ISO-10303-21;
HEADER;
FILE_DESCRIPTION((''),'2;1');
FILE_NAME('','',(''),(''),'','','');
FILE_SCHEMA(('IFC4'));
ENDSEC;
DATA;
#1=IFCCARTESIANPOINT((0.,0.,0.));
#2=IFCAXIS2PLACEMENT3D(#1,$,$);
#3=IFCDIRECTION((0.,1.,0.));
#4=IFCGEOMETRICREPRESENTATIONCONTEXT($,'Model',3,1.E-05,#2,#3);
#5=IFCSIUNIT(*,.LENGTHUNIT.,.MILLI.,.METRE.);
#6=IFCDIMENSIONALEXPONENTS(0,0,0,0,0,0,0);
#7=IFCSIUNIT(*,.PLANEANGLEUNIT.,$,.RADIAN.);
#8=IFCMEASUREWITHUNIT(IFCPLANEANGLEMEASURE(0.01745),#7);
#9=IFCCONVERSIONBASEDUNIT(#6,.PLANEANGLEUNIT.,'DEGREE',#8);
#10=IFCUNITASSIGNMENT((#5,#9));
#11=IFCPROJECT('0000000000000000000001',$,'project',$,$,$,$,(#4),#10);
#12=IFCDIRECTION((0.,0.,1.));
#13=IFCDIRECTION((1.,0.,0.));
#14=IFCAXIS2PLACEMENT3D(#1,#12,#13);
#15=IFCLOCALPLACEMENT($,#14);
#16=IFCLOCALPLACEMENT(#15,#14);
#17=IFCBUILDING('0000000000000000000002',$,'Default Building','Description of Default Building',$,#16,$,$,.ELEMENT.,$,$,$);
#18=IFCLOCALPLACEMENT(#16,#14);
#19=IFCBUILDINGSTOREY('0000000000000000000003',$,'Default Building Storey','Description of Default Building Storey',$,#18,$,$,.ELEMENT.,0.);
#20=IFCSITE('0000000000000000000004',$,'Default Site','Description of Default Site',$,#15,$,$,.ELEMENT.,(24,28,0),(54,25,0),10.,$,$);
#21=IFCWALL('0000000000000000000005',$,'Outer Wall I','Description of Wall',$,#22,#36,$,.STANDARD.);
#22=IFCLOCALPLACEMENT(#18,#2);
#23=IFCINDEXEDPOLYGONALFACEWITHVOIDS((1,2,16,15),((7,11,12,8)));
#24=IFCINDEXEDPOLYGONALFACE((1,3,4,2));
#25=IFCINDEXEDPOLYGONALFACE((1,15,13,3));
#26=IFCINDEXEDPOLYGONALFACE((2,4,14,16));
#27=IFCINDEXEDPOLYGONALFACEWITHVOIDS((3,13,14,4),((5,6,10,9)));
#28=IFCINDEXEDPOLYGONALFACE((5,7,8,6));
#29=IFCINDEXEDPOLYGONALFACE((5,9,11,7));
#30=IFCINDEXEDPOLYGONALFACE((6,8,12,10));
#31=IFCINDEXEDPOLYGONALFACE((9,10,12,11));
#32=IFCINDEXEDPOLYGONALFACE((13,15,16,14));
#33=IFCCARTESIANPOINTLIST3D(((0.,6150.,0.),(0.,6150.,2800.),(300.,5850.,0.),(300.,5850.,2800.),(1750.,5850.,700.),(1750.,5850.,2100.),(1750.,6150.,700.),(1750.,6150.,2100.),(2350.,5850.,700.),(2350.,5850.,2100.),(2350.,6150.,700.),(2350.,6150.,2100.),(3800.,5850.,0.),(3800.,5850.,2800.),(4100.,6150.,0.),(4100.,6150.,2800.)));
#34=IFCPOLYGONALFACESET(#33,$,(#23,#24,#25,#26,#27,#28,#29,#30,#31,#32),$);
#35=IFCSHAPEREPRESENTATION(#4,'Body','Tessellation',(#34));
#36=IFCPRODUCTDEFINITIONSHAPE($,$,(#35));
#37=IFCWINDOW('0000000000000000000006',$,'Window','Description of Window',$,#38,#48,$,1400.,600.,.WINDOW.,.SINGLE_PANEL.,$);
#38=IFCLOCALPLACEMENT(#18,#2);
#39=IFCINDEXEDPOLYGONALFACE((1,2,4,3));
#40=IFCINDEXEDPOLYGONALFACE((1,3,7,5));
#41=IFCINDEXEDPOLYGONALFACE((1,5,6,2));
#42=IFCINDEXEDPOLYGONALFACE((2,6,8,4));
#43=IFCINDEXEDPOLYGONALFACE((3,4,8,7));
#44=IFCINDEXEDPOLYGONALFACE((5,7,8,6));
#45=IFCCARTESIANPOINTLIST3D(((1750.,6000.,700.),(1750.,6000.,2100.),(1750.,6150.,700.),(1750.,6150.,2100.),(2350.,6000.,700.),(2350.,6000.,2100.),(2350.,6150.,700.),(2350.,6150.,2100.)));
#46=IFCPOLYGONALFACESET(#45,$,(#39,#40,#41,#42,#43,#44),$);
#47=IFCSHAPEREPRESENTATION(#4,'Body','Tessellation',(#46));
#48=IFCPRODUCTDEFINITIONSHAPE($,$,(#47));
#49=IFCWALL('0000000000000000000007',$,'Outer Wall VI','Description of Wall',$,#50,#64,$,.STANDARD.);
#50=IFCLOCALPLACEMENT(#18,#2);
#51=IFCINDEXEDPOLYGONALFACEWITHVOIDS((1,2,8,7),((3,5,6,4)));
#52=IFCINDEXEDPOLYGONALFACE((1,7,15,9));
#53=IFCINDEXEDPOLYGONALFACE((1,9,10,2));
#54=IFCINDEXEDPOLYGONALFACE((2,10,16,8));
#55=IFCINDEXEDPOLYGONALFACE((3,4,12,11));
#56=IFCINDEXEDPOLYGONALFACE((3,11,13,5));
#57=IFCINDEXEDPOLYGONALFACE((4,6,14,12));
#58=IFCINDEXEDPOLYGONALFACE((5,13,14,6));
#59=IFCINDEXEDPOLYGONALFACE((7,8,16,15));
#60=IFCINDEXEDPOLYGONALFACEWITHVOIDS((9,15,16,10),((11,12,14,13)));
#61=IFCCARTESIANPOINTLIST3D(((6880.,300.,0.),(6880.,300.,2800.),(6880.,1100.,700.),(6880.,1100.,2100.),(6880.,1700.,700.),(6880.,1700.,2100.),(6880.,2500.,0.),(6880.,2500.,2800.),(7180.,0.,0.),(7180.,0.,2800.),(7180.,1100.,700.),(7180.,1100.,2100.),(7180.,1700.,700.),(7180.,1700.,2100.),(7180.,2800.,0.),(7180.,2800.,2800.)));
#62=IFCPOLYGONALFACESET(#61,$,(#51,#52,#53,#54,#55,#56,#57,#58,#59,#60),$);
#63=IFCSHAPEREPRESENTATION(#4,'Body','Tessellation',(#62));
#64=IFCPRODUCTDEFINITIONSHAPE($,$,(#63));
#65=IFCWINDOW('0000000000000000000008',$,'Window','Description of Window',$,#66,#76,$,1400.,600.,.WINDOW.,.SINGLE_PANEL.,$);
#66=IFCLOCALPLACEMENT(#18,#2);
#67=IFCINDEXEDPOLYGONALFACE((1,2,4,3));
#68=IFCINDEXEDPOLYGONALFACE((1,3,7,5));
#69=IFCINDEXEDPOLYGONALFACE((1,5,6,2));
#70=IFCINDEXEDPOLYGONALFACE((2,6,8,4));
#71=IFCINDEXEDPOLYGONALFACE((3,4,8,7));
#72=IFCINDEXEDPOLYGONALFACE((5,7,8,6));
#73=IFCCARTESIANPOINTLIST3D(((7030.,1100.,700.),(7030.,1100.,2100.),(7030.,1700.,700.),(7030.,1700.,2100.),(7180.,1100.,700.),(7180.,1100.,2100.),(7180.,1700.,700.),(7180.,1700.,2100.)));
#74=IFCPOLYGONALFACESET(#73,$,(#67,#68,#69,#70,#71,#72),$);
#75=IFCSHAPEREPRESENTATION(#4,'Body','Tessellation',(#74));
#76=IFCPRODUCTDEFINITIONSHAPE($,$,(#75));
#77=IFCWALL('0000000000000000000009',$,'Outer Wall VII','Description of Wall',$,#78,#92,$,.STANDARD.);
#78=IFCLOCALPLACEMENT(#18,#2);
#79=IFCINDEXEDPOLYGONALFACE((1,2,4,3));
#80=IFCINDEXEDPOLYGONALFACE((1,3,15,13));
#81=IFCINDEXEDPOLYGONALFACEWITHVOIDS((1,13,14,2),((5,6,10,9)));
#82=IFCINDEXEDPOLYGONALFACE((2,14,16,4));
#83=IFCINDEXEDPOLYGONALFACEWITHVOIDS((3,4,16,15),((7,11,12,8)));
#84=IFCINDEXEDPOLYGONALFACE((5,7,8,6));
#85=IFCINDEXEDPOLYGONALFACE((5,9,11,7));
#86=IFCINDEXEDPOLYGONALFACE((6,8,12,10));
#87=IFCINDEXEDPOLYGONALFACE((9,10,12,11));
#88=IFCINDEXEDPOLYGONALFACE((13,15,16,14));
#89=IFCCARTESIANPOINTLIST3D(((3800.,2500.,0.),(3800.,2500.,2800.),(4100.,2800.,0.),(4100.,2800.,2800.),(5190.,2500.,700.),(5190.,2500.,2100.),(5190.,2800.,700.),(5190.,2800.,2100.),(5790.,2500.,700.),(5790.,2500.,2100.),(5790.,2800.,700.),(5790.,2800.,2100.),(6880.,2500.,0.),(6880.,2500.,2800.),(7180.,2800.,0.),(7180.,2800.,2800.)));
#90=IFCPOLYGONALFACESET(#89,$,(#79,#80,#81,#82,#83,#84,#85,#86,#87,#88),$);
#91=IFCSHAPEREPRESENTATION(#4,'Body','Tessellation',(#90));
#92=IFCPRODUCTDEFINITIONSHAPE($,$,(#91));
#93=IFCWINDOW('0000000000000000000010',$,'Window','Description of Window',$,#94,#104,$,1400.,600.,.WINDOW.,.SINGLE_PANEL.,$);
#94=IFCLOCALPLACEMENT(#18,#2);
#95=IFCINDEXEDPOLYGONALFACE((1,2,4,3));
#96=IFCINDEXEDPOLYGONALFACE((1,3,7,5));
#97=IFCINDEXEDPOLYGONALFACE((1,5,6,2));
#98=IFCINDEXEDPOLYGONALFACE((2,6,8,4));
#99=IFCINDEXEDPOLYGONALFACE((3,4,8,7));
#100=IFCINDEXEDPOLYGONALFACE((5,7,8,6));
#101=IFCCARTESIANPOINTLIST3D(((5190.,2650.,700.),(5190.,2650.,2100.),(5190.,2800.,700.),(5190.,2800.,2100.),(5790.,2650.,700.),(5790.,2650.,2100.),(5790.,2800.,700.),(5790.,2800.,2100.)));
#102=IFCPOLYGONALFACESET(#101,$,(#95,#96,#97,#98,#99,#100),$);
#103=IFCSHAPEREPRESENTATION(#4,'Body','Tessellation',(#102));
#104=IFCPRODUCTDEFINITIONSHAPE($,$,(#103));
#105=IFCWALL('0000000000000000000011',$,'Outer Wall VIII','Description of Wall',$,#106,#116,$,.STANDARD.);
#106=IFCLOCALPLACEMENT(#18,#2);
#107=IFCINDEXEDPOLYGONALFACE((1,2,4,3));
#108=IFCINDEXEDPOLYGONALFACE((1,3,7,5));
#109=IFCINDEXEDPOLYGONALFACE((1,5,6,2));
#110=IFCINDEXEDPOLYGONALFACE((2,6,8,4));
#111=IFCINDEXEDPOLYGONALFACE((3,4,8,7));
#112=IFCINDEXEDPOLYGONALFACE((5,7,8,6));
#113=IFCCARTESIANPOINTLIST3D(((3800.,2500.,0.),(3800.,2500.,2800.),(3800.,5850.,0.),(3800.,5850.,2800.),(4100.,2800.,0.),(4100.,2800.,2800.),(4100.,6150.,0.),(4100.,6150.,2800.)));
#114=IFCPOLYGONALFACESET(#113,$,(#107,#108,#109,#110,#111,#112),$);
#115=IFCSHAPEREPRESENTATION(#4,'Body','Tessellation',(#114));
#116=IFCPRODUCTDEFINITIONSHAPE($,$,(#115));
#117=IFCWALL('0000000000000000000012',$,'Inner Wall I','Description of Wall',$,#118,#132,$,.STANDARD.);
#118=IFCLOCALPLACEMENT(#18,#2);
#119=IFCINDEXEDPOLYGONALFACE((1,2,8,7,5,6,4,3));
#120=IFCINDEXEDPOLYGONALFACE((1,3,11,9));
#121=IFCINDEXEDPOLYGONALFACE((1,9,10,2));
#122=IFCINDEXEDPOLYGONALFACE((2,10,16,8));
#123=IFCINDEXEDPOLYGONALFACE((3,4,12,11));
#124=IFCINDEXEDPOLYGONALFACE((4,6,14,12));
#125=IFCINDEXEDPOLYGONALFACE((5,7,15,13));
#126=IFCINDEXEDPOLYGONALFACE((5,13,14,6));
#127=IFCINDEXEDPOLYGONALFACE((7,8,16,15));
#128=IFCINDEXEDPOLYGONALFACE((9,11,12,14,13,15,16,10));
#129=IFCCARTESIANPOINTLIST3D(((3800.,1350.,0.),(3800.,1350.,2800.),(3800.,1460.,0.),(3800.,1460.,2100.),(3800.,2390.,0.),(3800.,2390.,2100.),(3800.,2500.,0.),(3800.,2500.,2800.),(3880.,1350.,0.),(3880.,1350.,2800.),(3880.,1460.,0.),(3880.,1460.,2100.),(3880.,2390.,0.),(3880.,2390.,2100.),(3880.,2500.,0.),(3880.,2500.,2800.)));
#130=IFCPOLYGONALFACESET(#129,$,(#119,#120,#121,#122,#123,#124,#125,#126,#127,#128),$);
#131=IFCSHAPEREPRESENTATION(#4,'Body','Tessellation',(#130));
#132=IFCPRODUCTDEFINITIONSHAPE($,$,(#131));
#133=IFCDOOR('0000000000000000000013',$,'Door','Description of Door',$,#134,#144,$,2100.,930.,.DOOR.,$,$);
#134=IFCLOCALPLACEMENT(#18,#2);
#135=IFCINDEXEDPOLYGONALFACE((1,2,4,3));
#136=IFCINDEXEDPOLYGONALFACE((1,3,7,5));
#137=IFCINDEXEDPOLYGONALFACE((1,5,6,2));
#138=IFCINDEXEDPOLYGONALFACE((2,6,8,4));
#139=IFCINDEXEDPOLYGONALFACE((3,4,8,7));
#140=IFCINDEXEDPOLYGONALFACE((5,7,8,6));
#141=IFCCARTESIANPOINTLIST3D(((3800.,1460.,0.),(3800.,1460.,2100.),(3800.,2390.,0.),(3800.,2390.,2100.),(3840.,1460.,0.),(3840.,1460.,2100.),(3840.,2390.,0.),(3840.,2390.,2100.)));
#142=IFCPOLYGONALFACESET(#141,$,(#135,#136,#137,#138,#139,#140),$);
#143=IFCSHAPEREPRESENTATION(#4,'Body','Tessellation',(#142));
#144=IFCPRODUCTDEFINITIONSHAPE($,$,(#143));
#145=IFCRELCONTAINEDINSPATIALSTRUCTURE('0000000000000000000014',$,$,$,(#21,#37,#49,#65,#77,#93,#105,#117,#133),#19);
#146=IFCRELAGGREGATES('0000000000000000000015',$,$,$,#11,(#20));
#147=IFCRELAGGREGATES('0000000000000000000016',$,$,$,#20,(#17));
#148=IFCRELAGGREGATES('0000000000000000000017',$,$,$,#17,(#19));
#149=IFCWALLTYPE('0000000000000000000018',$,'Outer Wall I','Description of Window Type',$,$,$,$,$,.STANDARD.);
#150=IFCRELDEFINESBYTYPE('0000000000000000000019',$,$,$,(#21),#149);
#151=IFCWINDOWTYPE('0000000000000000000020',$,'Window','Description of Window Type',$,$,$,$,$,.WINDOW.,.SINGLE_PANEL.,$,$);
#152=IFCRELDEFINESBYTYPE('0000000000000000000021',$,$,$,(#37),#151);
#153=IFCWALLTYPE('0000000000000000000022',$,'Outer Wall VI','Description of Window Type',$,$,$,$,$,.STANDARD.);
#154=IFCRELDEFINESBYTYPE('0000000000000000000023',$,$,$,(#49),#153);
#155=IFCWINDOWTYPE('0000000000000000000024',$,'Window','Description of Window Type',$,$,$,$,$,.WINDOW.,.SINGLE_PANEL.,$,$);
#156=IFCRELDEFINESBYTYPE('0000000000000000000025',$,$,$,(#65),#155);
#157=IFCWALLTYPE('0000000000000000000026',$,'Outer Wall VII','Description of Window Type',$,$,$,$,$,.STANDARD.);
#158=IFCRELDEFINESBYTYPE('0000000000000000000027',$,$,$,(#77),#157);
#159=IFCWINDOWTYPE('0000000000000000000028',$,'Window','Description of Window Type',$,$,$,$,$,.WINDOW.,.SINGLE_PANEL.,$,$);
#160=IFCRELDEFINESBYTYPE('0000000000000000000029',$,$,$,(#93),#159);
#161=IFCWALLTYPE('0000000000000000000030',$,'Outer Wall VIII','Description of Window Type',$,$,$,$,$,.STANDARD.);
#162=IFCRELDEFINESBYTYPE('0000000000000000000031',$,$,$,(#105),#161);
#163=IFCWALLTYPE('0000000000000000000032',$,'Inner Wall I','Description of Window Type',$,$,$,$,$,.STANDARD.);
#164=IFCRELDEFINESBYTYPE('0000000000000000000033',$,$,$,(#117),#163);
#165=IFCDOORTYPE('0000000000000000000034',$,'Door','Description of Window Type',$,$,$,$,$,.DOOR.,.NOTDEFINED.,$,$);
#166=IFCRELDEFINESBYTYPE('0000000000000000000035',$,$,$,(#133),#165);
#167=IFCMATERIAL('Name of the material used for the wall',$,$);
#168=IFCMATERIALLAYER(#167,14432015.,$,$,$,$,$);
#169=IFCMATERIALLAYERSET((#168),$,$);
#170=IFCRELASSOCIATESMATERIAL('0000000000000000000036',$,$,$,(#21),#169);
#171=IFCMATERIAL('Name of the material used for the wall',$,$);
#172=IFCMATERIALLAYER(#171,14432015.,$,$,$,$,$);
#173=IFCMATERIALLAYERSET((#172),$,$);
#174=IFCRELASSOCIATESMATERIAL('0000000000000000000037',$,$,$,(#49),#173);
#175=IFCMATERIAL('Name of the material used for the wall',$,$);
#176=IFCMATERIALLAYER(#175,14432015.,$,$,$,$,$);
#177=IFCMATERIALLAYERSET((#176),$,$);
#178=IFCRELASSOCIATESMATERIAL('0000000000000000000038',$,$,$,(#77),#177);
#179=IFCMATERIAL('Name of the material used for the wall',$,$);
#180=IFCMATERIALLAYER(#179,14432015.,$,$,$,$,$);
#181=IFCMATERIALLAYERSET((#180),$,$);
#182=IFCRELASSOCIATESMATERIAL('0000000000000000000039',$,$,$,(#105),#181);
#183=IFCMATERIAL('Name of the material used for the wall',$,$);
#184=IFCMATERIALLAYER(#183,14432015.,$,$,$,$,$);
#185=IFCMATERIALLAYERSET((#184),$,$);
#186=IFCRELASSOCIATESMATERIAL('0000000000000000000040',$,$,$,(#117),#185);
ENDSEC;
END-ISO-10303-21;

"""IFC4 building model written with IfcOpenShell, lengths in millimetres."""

from ifc_helpers import new_model, entity, si_unit, converted_unit, direction, frame, origin, origin_with_axes, place, context, project, spatial, polyline, outline, extrude, material, layer, layer_set, layer_usage, type_object, element, fill, save


model = new_model("IFC4")

# Units and contexts
model_context = context("Model", 3, precision=1e-05, world=origin(), true_north=direction((0.0, 1.0, 0.0)))
ifc_project = project(units=[si_unit("LENGTHUNIT", "METRE", prefix="MILLI"), converted_unit("PLANEANGLEUNIT", "DEGREE", entity("IfcPlaneAngleMeasure", 0.01745), si_unit("PLANEANGLEUNIT", "RADIAN"), dimensions=[0, 0, 0, 0, 0, 0, 0])], contexts=[model_context])

# Site, building, storey
site_placement = place(None, origin_with_axes())
site = spatial("IfcSite", under=ifc_project, at=site_placement, Name="Default Site", Description="Description of Default Site", CompositionType="ELEMENT", RefLatitude=(24, 28, 0), RefLongitude=(54, 25, 0), RefElevation=10.0)
building_placement = place(site_placement, origin_with_axes())
building = spatial("IfcBuilding", under=site, at=building_placement, Name="Default Building", Description="Description of Default Building", CompositionType="ELEMENT")
storey_placement = place(building_placement, origin_with_axes())
storey = spatial("IfcBuildingStorey", under=building, at=storey_placement, Name="Default Building Storey", Description="Description of Default Building Storey", CompositionType="ELEMENT", Elevation=0.0)

# Walls, openings, windows
ifc_material_1 = material(Name="Name of the material used for the wall")
ifc_layer_1 = layer(ifc_material_1, 14432015.0)
ifc_layer_set_1 = layer_set([ifc_layer_1])
ifc_layer_usage_1 = layer_usage(ifc_layer_set_1, "AXIS2", "POSITIVE", -7216007.5)
wall_type_1 = type_object("IfcWallType", Name="Outer Wall I", Description="Description of Window Type", PredefinedType="STANDARD")
wall_1_placement = place(storey_placement, frame((3950.0, 6000.0, 0.0), z_axis=(0.0, 0.0, 1.0), x_axis=(-1.0, 0.0, 0.0)))
wall_1 = element("IfcWall", 1, at=wall_1_placement, inside=storey, type_object=wall_type_1, material=ifc_layer_usage_1, Name="Outer Wall I", Description="Description of Wall", PredefinedType="STANDARD", context=model_context, shape_type="SweptSolid", body=[
    extrude(outline(polyline([(-150.0, -150.0), (150.0, 150.0), (3650.0, 150.0), (3950.0, -150.0), (-150.0, -150.0)])), origin_with_axes(), (0.0, 0.0, 1.0), 2800.0),
])
opening_1_placement = place(wall_1_placement, frame((1600.0, -150.0, 700.0), z_axis=(0.0, 0.0, 1.0), x_axis=(1.0, 0.0, 0.0)))
opening_1 = element("IfcOpeningElement", 2, at=opening_1_placement, cuts=wall_1, context=model_context, shape_type="SweptSolid", body=[
    extrude(outline(polyline([(0.0, 0.0), (0.0, 300.0), (600.0, 300.0), (600.0, 0.0), (0.0, 0.0)])), origin_with_axes(), (0.0, 0.0, 1.0), 1400.0),
])
window_type_1 = type_object("IfcWindowType", Name="Window", Description="Description of Window Type", PartitioningType="SINGLE_PANEL", PredefinedType="WINDOW")
window_1_placement = place(opening_1_placement, origin_with_axes())
window_1 = element("IfcWindow", 3, at=window_1_placement, inside=storey, type_object=window_type_1, Name="Window", Description="Description of Window", OverallHeight=1400.0, OverallWidth=600.0, PartitioningType="SINGLE_PANEL", PredefinedType="WINDOW", context=model_context, shape_type="SweptSolid", body=[
    extrude(outline(polyline([(0.0, 0.0), (0.0, 150.0), (600.0, 150.0), (600.0, 0.0), (0.0, 0.0)])), origin_with_axes(), (0.0, 0.0, 1.0), 1400.0),
])
fill(opening_1, window_1)
ifc_material_2 = material(Name="Name of the material used for the wall")
ifc_layer_2 = layer(ifc_material_2, 14432015.0)
ifc_layer_set_2 = layer_set([ifc_layer_2])
ifc_layer_usage_2 = layer_usage(ifc_layer_set_2, "AXIS2", "POSITIVE", -7216007.5)
wall_type_2 = type_object("IfcWallType", Name="Outer Wall VI", Description="Description of Window Type", PredefinedType="STANDARD")
wall_2_placement = place(storey_placement, frame((7030.0, 150.0, 0.0), z_axis=(0.0, 0.0, 1.0), x_axis=(0.0, 1.0, 0.0)))
wall_2 = element("IfcWall", 4, at=wall_2_placement, inside=storey, type_object=wall_type_2, material=ifc_layer_usage_2, Name="Outer Wall VI", Description="Description of Wall", PredefinedType="STANDARD", context=model_context, shape_type="SweptSolid", body=[
    extrude(outline(polyline([(-150.0, -150.0), (150.0, 150.0), (2350.0, 150.0), (2650.0, -150.0), (-150.0, -150.0)])), origin_with_axes(), (0.0, 0.0, 1.0), 2800.0),
])
opening_2_placement = place(wall_2_placement, frame((950.0, -150.0, 700.0), z_axis=(0.0, 0.0, 1.0), x_axis=(1.0, 0.0, 0.0)))
opening_2 = element("IfcOpeningElement", 5, at=opening_2_placement, cuts=wall_2, context=model_context, shape_type="SweptSolid", body=[
    extrude(outline(polyline([(0.0, 0.0), (0.0, 300.0), (600.0, 300.0), (600.0, 0.0), (0.0, 0.0)])), origin_with_axes(), (0.0, 0.0, 1.0), 1400.0),
])
window_type_2 = type_object("IfcWindowType", Name="Window", Description="Description of Window Type", PartitioningType="SINGLE_PANEL", PredefinedType="WINDOW")
window_2_placement = place(opening_2_placement, origin_with_axes())
window_2 = element("IfcWindow", 6, at=window_2_placement, inside=storey, type_object=window_type_2, Name="Window", Description="Description of Window", OverallHeight=1400.0, OverallWidth=600.0, PartitioningType="SINGLE_PANEL", PredefinedType="WINDOW", context=model_context, shape_type="SweptSolid", body=[
    extrude(outline(polyline([(0.0, 0.0), (0.0, 150.0), (600.0, 150.0), (600.0, 0.0), (0.0, 0.0)])), origin_with_axes(), (0.0, 0.0, 1.0), 1400.0),
])
fill(opening_2, window_2)
ifc_material_3 = material(Name="Name of the material used for the wall")
ifc_layer_3 = layer(ifc_material_3, 14432015.0)
ifc_layer_set_3 = layer_set([ifc_layer_3])
ifc_layer_usage_3 = layer_usage(ifc_layer_set_3, "AXIS2", "POSITIVE", -7216007.5)
wall_type_3 = type_object("IfcWallType", Name="Outer Wall VII", Description="Description of Window Type", PredefinedType="STANDARD")
wall_3_placement = place(storey_placement, frame((7030.0, 2650.0, 0.0), z_axis=(0.0, 0.0, 1.0), x_axis=(-1.0, 0.0, 0.0)))
wall_3 = element("IfcWall", 7, at=wall_3_placement, inside=storey, type_object=wall_type_3, material=ifc_layer_usage_3, Name="Outer Wall VII", Description="Description of Wall", PredefinedType="STANDARD", context=model_context, shape_type="SweptSolid", body=[
    extrude(outline(polyline([(-150.0, -150.0), (150.0, 150.0), (3230.0, 150.0), (2930.0, -150.0), (-150.0, -150.0)])), origin_with_axes(), (0.0, 0.0, 1.0), 2800.0),
])
opening_3_placement = place(wall_3_placement, frame((1240.0, -150.0, 700.0), z_axis=(0.0, 0.0, 1.0), x_axis=(1.0, 0.0, 0.0)))
opening_3 = element("IfcOpeningElement", 8, at=opening_3_placement, cuts=wall_3, context=model_context, shape_type="SweptSolid", body=[
    extrude(outline(polyline([(0.0, 0.0), (0.0, 300.0), (600.0, 300.0), (600.0, 0.0), (0.0, 0.0)])), origin_with_axes(), (0.0, 0.0, 1.0), 1400.0),
])
window_type_3 = type_object("IfcWindowType", Name="Window", Description="Description of Window Type", PartitioningType="SINGLE_PANEL", PredefinedType="WINDOW")
window_3_placement = place(opening_3_placement, origin_with_axes())
window_3 = element("IfcWindow", 9, at=window_3_placement, inside=storey, type_object=window_type_3, Name="Window", Description="Description of Window", OverallHeight=1400.0, OverallWidth=600.0, PartitioningType="SINGLE_PANEL", PredefinedType="WINDOW", context=model_context, shape_type="SweptSolid", body=[
    extrude(outline(polyline([(0.0, 0.0), (0.0, 150.0), (600.0, 150.0), (600.0, 0.0), (0.0, 0.0)])), origin_with_axes(), (0.0, 0.0, 1.0), 1400.0),
])
fill(opening_3, window_3)

# Wall
ifc_material_4 = material(Name="Name of the material used for the wall")
ifc_layer_4 = layer(ifc_material_4, 14432015.0)
ifc_layer_set_4 = layer_set([ifc_layer_4])
ifc_layer_usage_4 = layer_usage(ifc_layer_set_4, "AXIS2", "POSITIVE", -7216007.5)
wall_type_4 = type_object("IfcWallType", Name="Outer Wall VIII", Description="Description of Window Type", PredefinedType="STANDARD")
wall_4_placement = place(storey_placement, frame((3950.0, 2650.0, 0.0), z_axis=(0.0, 0.0, 1.0), x_axis=(0.0, 1.0, 0.0)))
element("IfcWall", 10, at=wall_4_placement, inside=storey, type_object=wall_type_4, material=ifc_layer_usage_4, Name="Outer Wall VIII", Description="Description of Wall", PredefinedType="STANDARD", context=model_context, shape_type="SweptSolid", body=[
    extrude(outline(polyline([(150.0, -150.0), (-150.0, 150.0), (3200.0, 150.0), (3500.0, -150.0), (150.0, -150.0)])), origin_with_axes(), (0.0, 0.0, 1.0), 2800.0),
])

# Wall, opening, door
ifc_material_5 = material(Name="Name of the material used for the wall")
ifc_layer_5 = layer(ifc_material_5, 14432015.0)
ifc_layer_set_5 = layer_set([ifc_layer_5])
ifc_layer_usage_5 = layer_usage(ifc_layer_set_5, "AXIS2", "POSITIVE", -7216007.5)
wall_type_5 = type_object("IfcWallType", Name="Inner Wall I", Description="Description of Window Type", PredefinedType="STANDARD")
wall_5_placement = place(storey_placement, frame((3840.0, 2500.0, 0.0), z_axis=(0.0, 0.0, 1.0), x_axis=(0.0, -1.0, 0.0)))
wall_5 = element("IfcWall", 11, at=wall_5_placement, inside=storey, type_object=wall_type_5, material=ifc_layer_usage_5, Name="Inner Wall I", Description="Description of Wall", PredefinedType="STANDARD", context=model_context, shape_type="SweptSolid", body=[
    extrude(outline(polyline([(0.0, -40.0), (0.0, 40.0), (1150.0, 40.0), (1150.0, -40.0), (0.0, -40.0)])), origin_with_axes(), (0.0, 0.0, 1.0), 2800.0),
])
opening_4_placement = place(wall_5_placement, frame((110.0, -40.0, 0.0), z_axis=(0.0, 0.0, 1.0), x_axis=(1.0, 0.0, 0.0)))
opening_4 = element("IfcOpeningElement", 12, at=opening_4_placement, cuts=wall_5, context=model_context, shape_type="SweptSolid", body=[
    extrude(outline(polyline([(0.0, 0.0), (0.0, 80.0), (930.0, 80.0), (930.0, 0.0), (0.0, 0.0)])), origin_with_axes(), (0.0, 0.0, 1.0), 2100.0),
])
door_type_1 = type_object("IfcDoorType", Name="Door", Description="Description of Window Type", PredefinedType="DOOR")
door_1_placement = place(opening_4_placement, origin_with_axes())
door_1 = element("IfcDoor", 13, at=door_1_placement, inside=storey, type_object=door_type_1, Name="Door", Description="Description of Door", OverallHeight=2100.0, OverallWidth=930.0, PredefinedType="DOOR", context=model_context, shape_type="SweptSolid", body=[
    extrude(outline(polyline([(0.0, 0.0), (0.0, 40.0), (930.0, 40.0), (930.0, 0.0), (0.0, 0.0)])), origin_with_axes(), (0.0, 0.0, 1.0), 2100.0),
])
fill(opening_4, door_1)

save(model, "model.ifc")
